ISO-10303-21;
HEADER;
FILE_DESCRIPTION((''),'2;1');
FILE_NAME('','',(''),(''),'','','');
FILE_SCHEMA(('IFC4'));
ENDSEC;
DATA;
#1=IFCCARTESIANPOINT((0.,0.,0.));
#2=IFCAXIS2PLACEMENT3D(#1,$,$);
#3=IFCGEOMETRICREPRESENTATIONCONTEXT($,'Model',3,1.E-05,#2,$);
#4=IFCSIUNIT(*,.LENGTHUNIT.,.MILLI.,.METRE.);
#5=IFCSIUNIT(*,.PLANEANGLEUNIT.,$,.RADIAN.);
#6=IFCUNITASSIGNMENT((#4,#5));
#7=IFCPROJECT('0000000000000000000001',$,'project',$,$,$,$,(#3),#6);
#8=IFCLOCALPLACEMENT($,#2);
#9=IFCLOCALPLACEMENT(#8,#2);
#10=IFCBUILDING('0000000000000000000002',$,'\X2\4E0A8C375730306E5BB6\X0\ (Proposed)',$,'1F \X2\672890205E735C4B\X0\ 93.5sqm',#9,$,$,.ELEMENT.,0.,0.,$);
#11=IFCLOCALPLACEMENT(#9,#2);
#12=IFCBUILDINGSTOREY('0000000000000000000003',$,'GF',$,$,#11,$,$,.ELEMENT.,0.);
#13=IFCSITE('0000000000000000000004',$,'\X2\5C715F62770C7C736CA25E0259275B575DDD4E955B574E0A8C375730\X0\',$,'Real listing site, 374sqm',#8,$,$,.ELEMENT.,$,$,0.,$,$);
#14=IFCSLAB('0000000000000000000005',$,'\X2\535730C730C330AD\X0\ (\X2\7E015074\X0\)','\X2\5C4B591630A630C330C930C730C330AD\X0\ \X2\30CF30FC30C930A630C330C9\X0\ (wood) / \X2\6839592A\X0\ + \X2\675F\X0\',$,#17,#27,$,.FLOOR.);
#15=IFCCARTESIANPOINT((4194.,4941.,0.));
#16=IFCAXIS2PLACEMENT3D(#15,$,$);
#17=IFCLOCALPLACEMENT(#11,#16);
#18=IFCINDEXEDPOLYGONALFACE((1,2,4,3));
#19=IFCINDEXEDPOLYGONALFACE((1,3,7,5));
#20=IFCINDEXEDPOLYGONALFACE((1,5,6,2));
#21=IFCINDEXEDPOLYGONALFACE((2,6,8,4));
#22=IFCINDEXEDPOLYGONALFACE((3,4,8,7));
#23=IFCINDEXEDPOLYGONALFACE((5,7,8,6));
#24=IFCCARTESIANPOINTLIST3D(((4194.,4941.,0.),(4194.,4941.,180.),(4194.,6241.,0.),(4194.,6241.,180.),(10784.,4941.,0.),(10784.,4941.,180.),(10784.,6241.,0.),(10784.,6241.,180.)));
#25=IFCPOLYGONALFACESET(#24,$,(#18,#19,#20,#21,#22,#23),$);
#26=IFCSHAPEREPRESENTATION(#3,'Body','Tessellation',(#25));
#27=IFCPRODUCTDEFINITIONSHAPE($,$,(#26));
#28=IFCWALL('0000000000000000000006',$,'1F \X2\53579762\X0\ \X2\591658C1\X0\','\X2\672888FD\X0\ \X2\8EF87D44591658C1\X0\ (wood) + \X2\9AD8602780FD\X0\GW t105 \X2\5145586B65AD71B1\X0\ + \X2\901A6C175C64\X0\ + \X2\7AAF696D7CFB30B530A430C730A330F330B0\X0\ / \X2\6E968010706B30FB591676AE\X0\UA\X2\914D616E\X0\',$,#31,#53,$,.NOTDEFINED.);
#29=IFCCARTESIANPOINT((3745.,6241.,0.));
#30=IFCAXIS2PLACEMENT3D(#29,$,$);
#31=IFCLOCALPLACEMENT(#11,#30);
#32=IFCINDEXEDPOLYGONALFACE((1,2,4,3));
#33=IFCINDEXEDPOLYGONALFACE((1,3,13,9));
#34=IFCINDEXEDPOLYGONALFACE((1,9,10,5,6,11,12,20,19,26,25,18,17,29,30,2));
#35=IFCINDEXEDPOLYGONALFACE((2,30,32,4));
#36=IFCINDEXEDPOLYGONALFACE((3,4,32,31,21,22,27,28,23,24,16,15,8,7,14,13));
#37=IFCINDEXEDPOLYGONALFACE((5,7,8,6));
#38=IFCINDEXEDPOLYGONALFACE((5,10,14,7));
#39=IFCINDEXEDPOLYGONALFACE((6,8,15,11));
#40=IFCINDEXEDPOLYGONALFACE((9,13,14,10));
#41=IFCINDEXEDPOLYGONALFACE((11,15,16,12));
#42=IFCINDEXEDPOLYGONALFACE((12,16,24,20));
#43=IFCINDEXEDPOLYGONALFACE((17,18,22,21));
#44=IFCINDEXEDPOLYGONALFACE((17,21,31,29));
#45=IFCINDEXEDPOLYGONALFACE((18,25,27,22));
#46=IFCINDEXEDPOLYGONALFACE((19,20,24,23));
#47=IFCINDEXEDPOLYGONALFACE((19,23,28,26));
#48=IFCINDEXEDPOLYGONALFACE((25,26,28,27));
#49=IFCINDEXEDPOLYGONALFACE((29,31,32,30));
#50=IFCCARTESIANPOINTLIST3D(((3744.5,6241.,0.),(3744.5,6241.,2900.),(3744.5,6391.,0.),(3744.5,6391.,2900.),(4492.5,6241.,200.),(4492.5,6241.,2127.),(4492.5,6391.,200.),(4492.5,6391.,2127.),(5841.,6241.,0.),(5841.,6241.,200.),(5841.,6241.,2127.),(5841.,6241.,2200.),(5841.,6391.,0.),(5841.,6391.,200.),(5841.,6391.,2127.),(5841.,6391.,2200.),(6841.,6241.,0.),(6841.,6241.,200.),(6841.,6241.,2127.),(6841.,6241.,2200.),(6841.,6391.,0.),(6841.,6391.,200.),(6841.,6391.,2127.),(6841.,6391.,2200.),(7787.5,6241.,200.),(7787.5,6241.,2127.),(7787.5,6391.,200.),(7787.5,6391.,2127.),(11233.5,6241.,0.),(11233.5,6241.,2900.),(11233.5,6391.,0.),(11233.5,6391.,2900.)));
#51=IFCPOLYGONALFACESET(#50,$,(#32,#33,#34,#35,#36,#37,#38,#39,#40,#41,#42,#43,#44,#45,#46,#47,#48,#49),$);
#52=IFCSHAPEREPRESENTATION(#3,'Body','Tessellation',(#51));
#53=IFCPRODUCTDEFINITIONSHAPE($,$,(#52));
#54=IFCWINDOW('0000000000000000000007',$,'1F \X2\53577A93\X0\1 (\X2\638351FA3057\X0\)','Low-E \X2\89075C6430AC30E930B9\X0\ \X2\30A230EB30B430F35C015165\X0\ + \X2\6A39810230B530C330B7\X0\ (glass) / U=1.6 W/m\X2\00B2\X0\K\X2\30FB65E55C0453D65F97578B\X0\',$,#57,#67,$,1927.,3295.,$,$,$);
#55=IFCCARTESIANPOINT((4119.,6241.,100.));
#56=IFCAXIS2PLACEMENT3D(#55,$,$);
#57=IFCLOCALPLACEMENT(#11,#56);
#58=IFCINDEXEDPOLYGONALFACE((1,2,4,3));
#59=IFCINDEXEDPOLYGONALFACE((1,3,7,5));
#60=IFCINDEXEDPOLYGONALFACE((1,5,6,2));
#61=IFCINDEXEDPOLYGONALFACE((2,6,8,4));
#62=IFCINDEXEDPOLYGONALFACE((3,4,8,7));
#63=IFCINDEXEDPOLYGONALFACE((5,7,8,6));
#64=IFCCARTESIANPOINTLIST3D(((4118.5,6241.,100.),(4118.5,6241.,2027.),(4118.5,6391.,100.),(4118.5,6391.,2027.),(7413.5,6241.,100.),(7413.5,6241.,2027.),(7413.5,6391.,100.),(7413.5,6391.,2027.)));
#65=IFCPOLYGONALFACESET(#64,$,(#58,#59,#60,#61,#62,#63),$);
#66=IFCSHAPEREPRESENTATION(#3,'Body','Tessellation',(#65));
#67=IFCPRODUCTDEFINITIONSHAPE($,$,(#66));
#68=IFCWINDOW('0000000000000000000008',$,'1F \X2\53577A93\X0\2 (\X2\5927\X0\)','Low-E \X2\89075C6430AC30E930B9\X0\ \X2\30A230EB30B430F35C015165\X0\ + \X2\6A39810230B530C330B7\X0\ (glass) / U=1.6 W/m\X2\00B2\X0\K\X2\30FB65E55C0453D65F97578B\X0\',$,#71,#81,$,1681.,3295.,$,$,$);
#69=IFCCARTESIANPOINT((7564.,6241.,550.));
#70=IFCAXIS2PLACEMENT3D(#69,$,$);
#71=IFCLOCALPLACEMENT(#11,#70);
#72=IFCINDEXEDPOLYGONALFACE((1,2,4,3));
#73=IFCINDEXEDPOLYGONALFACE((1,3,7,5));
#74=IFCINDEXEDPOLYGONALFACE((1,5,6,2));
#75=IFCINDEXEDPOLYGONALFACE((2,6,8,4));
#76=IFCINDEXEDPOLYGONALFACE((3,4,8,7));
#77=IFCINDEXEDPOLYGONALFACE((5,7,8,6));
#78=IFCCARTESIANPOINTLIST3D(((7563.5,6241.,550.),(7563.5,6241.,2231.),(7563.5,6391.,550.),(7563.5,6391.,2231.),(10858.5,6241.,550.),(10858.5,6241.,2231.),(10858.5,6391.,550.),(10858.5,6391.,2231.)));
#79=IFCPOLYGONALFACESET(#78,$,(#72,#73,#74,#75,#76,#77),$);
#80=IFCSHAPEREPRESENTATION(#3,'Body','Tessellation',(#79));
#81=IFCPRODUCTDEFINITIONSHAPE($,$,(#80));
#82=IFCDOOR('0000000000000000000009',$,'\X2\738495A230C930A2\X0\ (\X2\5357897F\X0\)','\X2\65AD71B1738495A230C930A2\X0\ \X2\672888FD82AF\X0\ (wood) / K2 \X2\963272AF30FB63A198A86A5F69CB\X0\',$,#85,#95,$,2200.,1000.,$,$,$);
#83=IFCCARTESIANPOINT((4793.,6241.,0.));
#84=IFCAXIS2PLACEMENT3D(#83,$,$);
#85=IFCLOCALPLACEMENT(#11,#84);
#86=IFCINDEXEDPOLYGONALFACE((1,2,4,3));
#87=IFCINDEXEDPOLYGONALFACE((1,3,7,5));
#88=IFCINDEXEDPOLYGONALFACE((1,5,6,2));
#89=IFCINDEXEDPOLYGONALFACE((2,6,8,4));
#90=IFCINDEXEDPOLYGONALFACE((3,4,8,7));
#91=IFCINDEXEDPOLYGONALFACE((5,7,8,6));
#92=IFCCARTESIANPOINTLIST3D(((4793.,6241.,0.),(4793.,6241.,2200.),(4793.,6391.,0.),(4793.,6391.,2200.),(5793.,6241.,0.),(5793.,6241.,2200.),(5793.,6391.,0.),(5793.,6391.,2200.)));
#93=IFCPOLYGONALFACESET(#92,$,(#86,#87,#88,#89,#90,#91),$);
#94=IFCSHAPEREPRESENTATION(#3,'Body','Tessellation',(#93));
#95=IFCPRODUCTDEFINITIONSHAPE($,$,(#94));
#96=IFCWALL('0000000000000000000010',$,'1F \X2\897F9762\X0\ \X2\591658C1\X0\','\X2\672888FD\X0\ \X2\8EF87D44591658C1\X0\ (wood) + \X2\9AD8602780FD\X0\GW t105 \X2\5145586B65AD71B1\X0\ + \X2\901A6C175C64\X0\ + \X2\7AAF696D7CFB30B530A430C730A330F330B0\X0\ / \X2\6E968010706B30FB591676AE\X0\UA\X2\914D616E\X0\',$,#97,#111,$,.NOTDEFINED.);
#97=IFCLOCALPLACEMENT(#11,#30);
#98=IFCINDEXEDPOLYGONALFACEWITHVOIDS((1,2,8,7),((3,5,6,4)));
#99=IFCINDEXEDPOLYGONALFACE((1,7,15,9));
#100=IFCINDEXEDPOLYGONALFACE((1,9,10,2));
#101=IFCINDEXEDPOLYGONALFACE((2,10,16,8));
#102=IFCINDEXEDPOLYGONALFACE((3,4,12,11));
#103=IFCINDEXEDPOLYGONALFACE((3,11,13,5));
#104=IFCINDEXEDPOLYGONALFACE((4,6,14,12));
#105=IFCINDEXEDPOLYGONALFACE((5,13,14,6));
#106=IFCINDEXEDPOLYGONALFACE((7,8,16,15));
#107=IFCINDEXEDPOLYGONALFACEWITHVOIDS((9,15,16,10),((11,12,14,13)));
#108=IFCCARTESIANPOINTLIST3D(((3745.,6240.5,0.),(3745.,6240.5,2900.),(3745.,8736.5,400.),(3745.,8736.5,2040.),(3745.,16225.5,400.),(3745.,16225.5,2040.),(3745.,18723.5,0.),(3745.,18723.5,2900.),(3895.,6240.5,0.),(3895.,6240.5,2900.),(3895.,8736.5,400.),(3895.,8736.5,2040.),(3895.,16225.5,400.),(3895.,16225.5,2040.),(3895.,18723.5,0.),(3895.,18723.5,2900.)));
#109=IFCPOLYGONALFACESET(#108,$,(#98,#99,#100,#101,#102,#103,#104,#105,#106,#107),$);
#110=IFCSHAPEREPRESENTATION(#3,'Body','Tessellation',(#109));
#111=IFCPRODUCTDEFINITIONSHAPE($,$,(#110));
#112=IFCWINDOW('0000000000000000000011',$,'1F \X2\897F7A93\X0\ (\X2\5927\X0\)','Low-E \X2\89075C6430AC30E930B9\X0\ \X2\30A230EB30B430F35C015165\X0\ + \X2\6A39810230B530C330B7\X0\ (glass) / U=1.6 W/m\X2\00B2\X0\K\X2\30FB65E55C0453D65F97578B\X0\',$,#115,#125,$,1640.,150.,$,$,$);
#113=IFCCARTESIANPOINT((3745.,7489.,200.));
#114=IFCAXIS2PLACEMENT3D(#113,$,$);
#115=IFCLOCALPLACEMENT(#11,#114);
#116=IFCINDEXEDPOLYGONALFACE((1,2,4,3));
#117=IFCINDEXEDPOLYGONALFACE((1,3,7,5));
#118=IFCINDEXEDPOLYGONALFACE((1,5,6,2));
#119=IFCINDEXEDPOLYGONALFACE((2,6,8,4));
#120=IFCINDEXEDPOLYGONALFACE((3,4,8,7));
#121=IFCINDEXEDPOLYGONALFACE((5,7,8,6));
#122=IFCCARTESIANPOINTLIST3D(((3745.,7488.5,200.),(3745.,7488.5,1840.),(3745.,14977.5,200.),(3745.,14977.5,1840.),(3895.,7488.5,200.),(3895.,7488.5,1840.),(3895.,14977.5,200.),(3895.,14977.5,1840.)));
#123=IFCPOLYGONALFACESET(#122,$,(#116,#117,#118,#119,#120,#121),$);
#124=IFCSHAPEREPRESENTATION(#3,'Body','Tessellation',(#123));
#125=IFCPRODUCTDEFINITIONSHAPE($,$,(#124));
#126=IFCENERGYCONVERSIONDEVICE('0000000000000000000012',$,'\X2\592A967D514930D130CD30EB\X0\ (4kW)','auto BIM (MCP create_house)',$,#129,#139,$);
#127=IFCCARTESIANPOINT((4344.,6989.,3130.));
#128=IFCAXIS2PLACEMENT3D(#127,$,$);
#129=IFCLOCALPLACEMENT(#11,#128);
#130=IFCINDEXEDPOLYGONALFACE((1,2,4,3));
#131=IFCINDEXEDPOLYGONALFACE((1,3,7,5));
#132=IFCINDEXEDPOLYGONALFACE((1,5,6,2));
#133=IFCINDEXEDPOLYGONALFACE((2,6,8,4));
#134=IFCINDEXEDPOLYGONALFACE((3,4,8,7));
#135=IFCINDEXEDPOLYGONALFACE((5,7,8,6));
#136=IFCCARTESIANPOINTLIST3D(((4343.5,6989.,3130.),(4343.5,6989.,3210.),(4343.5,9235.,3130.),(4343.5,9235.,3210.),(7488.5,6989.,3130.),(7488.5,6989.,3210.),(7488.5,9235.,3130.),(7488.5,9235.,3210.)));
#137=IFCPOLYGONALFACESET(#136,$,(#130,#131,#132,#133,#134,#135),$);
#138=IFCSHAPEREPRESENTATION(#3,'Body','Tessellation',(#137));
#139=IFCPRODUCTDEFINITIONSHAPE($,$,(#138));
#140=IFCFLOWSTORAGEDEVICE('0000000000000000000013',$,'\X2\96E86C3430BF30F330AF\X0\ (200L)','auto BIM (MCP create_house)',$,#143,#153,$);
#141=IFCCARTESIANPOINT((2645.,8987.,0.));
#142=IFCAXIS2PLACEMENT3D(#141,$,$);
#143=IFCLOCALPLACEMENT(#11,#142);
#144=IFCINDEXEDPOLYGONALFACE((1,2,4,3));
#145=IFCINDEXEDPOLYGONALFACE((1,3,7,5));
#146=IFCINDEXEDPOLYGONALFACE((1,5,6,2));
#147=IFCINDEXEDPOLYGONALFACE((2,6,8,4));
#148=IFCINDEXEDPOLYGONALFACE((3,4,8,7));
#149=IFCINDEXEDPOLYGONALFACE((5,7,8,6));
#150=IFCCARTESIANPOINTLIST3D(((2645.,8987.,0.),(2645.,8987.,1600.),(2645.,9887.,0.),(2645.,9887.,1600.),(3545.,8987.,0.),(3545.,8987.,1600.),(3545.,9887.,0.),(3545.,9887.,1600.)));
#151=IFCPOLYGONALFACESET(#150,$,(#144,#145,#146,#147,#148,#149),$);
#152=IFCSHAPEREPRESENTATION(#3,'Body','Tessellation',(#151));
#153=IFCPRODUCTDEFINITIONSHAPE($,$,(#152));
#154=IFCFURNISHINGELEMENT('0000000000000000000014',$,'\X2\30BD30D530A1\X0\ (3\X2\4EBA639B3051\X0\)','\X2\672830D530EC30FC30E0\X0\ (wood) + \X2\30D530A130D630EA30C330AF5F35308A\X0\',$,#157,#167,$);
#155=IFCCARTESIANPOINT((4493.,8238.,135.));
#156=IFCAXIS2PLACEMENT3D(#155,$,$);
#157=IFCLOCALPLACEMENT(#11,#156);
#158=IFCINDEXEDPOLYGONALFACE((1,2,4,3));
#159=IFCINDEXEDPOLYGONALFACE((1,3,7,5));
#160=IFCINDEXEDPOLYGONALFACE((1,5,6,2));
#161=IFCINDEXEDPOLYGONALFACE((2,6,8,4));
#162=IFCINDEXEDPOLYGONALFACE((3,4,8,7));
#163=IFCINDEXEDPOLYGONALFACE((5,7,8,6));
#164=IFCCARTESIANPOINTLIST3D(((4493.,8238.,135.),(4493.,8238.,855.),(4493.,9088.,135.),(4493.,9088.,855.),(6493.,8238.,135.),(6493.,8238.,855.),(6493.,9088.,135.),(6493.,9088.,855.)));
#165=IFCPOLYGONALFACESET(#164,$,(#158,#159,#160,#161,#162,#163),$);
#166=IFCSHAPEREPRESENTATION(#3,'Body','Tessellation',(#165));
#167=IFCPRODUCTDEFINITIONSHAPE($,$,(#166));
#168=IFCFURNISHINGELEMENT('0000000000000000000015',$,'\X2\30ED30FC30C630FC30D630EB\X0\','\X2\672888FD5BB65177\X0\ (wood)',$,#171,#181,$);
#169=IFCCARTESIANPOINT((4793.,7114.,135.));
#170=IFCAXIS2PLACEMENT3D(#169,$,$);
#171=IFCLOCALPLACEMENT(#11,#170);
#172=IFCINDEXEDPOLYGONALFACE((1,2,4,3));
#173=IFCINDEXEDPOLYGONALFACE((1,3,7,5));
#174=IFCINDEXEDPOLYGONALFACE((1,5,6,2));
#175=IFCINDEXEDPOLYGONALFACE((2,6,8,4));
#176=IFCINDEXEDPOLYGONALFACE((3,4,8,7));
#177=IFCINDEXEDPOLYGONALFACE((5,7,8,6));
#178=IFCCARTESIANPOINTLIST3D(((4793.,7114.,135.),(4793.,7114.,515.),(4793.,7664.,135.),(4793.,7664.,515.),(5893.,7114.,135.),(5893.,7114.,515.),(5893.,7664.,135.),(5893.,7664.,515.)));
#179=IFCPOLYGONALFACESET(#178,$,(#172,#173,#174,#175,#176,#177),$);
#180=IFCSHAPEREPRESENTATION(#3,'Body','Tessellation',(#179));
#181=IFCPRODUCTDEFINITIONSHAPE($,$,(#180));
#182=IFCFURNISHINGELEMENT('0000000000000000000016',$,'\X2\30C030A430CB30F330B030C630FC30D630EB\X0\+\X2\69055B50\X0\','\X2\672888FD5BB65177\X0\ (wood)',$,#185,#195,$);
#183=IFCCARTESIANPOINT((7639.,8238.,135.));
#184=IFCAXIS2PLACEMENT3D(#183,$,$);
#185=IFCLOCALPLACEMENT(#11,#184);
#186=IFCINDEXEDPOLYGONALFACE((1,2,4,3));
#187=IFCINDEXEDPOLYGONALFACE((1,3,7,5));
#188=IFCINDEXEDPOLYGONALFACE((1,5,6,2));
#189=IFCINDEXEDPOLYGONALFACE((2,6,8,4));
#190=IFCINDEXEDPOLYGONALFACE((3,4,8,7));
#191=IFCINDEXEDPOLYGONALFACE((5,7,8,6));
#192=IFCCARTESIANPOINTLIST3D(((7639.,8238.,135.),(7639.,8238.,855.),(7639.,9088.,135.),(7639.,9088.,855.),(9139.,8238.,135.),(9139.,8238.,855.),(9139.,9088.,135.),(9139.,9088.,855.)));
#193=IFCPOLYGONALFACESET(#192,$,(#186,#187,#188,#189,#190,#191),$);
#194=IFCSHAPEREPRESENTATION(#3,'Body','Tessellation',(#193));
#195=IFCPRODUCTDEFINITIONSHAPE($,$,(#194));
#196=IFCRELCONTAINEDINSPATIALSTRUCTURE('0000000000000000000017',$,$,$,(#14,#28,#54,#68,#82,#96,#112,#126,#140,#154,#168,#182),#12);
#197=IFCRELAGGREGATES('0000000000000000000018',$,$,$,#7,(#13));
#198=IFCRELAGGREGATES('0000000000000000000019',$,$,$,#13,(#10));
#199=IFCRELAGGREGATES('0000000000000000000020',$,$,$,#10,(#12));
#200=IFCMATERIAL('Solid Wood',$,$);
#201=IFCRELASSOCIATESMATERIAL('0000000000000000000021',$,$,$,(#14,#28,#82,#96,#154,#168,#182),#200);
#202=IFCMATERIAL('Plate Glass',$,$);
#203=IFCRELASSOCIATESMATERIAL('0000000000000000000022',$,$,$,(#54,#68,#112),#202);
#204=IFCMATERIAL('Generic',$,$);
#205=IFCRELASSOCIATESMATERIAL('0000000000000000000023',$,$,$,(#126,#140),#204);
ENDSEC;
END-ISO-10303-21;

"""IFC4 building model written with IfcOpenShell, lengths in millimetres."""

from ifc_helpers import new_model, si_unit, frame, frame_2d, origin, place, context, project, spatial, rectangle, extrude, material, element, fill, save


model = new_model("IFC4")

# Units and contexts
model_context = context("Model", 3, precision=1e-05, world=origin())
ifc_project = project(units=[si_unit("LENGTHUNIT", "METRE", prefix="MILLI"), si_unit("PLANEANGLEUNIT", "RADIAN")], contexts=[model_context])

# Site, building, storey
site_placement = place(None, origin())
site = spatial("IfcSite", under=ifc_project, at=site_placement, Name="山形県米沢市大字川井字上谷地", ObjectType="Real listing site, 374sqm", CompositionType="ELEMENT", RefElevation=0.0)
building_placement = place(site_placement, origin())
building = spatial("IfcBuilding", under=site, at=building_placement, Name="上谷地の家 (Proposed)", ObjectType="1F 木造平屋 93.5sqm", CompositionType="ELEMENT", ElevationOfRefHeight=0.0, ElevationOfTerrain=0.0)
storey_placement = place(building_placement, origin())
storey = spatial("IfcBuildingStorey", under=building, at=storey_placement, Name="GF", CompositionType="ELEMENT", Elevation=0.0)

# Slab
ifc_material_1 = material(Name="Solid Wood")
slab_1_placement = place(storey_placement, frame((4194.0, 4941.0, 0.0)))
element("IfcSlab", 1, at=slab_1_placement, inside=storey, material=ifc_material_1, Name="南デッキ (縁側)", Description="屋外ウッドデッキ ハードウッド (wood) / 根太 + 束", PredefinedType="FLOOR", context=model_context, shape_type="SweptSolid", body=[
    extrude(rectangle(XDim=6590.0, YDim=1300.0, at=frame_2d((3295.0, 650.0))), frame((4194.0, 4941.0, 0.0)), (0.0, 0.0, 1.0), 180.0),
])

# Wall, openings, windows, door
wall_1_placement = place(storey_placement, frame((3745.0, 6241.0, 0.0)))
wall_1 = element("IfcWall", 2, at=wall_1_placement, inside=storey, material=ifc_material_1, Name="1F 南面 外壁", Description="木製 軸組外壁 (wood) + 高性能GW t105 充填断熱 + 通気層 + 窯業系サイディング / 準耐火・外皮UA配慮", PredefinedType="NOTDEFINED", context=model_context, shape_type="SweptSolid", body=[
    extrude(rectangle(XDim=7489.0, YDim=150.0, at=frame_2d((3744.0, 75.0))), frame((3745.0, 6241.0, 0.0)), (0.0, 0.0, 1.0), 2900.0),
])
opening_1_placement = place(storey_placement, frame((4119.0, 6241.0, 100.0)))
opening_1 = element("IfcOpeningElement", 3, at=opening_1_placement, cuts=wall_1, PredefinedType="NOTDEFINED", context=model_context, shape_type="SweptSolid", body=[
    extrude(rectangle(XDim=3295.0, YDim=150.0, at=frame_2d((1647.0, 75.0))), frame((4119.0, 6241.0, 100.0)), (0.0, 0.0, 1.0), 1927.0),
])
opening_2_placement = place(storey_placement, frame((7564.0, 6241.0, 550.0)))
opening_2 = element("IfcOpeningElement", 4, at=opening_2_placement, cuts=wall_1, PredefinedType="NOTDEFINED", context=model_context, shape_type="SweptSolid", body=[
    extrude(rectangle(XDim=3295.0, YDim=150.0, at=frame_2d((1647.0, 75.0))), frame((7564.0, 6241.0, 550.0)), (0.0, 0.0, 1.0), 1681.0),
])
opening_3_placement = place(storey_placement, frame((4793.0, 6241.0, 0.0)))
opening_3 = element("IfcOpeningElement", 5, at=opening_3_placement, cuts=wall_1, PredefinedType="NOTDEFINED", context=model_context, shape_type="SweptSolid", body=[
    extrude(rectangle(XDim=1000.0, YDim=150.0, at=frame_2d((500.0, 75.0))), frame((4793.0, 6241.0, 0.0)), (0.0, 0.0, 1.0), 2200.0),
])
ifc_material_2 = material(Name="Plate Glass")
window_1_placement = place(storey_placement, frame((4119.0, 6241.0, 100.0)))
window_1 = element("IfcWindow", 6, at=window_1_placement, inside=storey, material=ifc_material_2, Name="1F 南窓1 (掃出し)", Description="Low-E 複層ガラス アルゴン封入 + 樹脂サッシ (glass) / U=1.6 W/m²K・日射取得型", OverallHeight=1927.0, OverallWidth=3295.0, context=model_context, shape_type="SweptSolid", body=[
    extrude(rectangle(XDim=3295.0, YDim=150.0, at=frame_2d((1647.0, 75.0))), frame((4119.0, 6241.0, 100.0)), (0.0, 0.0, 1.0), 1927.0),
])
fill(opening_1, window_1)
window_2_placement = place(storey_placement, frame((7564.0, 6241.0, 550.0)))
window_2 = element("IfcWindow", 7, at=window_2_placement, inside=storey, material=ifc_material_2, Name="1F 南窓2 (大)", Description="Low-E 複層ガラス アルゴン封入 + 樹脂サッシ (glass) / U=1.6 W/m²K・日射取得型", OverallHeight=1681.0, OverallWidth=3295.0, context=model_context, shape_type="SweptSolid", body=[
    extrude(rectangle(XDim=3295.0, YDim=150.0, at=frame_2d((1647.0, 75.0))), frame((7564.0, 6241.0, 550.0)), (0.0, 0.0, 1.0), 1681.0),
])
fill(opening_2, window_2)
door_placement = place(storey_placement, frame((4793.0, 6241.0, 0.0)))
door = element("IfcDoor", 8, at=door_placement, inside=storey, material=ifc_material_1, Name="玄関ドア (南西)", Description="断熱玄関ドア 木製芯 (wood) / K2 防犯・採風機構", OverallHeight=2200.0, OverallWidth=1000.0, context=model_context, shape_type="SweptSolid", body=[
    extrude(rectangle(XDim=1000.0, YDim=150.0, at=frame_2d((500.0, 75.0))), frame((4793.0, 6241.0, 0.0)), (0.0, 0.0, 1.0), 2200.0),
])
fill(opening_3, door)

# Wall, opening, window
wall_2_placement = place(storey_placement, frame((3745.0, 6241.0, 0.0)))
wall_2 = element("IfcWall", 9, at=wall_2_placement, inside=storey, material=ifc_material_1, Name="1F 西面 外壁", Description="木製 軸組外壁 (wood) + 高性能GW t105 充填断熱 + 通気層 + 窯業系サイディング / 準耐火・外皮UA配慮", PredefinedType="NOTDEFINED", context=model_context, shape_type="SweptSolid", body=[
    extrude(rectangle(XDim=150.0, YDim=12483.0, at=frame_2d((75.0, 6241.0))), frame((3745.0, 6241.0, 0.0)), (0.0, 0.0, 1.0), 2900.0),
])
opening_4_placement = place(storey_placement, frame((3745.0, 7489.0, 200.0)))
opening_4 = element("IfcOpeningElement", 10, at=opening_4_placement, cuts=wall_2, PredefinedType="NOTDEFINED", context=model_context, shape_type="SweptSolid", body=[
    extrude(rectangle(XDim=150.0, YDim=7489.0, at=frame_2d((75.0, 3744.0))), frame((3745.0, 7489.0, 200.0)), (0.0, 0.0, 1.0), 1640.0),
])
window_3_placement = place(storey_placement, frame((3745.0, 7489.0, 200.0)))
window_3 = element("IfcWindow", 11, at=window_3_placement, inside=storey, material=ifc_material_2, Name="1F 西窓 (大)", Description="Low-E 複層ガラス アルゴン封入 + 樹脂サッシ (glass) / U=1.6 W/m²K・日射取得型", OverallHeight=1640.0, OverallWidth=150.0, context=model_context, shape_type="SweptSolid", body=[
    extrude(rectangle(XDim=150.0, YDim=7489.0, at=frame_2d((75.0, 3744.0))), frame((3745.0, 7489.0, 200.0)), (0.0, 0.0, 1.0), 1640.0),
])
fill(opening_4, window_3)

# Shared definitions
ifc_material_3 = material(Name="Generic")

# Energy conversion device
energy_conversion_device_placement = place(storey_placement, frame((4344.0, 6989.0, 3130.0)))
element("IfcEnergyConversionDevice", 12, at=energy_conversion_device_placement, inside=storey, material=ifc_material_3, Name="太陽光パネル (4kW)", Description="auto BIM (MCP create_house)", context=model_context, shape_type="SweptSolid", body=[
    extrude(rectangle(XDim=3145.0, YDim=2246.0, at=frame_2d((1572.0, 1123.0))), frame((4344.0, 6989.0, 3130.0)), (0.0, 0.0, 1.0), 80.0),
])

# Flow storage device
flow_storage_device_placement = place(storey_placement, frame((2645.0, 8987.0, 0.0)))
element("IfcFlowStorageDevice", 13, at=flow_storage_device_placement, inside=storey, material=ifc_material_3, Name="雨水タンク (200L)", Description="auto BIM (MCP create_house)", context=model_context, shape_type="SweptSolid", body=[
    extrude(rectangle(XDim=900.0, YDim=900.0, at=frame_2d((450.0, 450.0))), frame((2645.0, 8987.0, 0.0)), (0.0, 0.0, 1.0), 1600.0),
])

# Furnishing elements
furnishing_1_placement = place(storey_placement, frame((4493.0, 8238.0, 135.0)))
element("IfcFurnishingElement", 14, at=furnishing_1_placement, inside=storey, material=ifc_material_1, Name="ソファ (3人掛け)", Description="木フレーム (wood) + ファブリック張り", context=model_context, shape_type="SweptSolid", body=[
    extrude(rectangle(XDim=2000.0, YDim=850.0, at=frame_2d((1000.0, 425.0))), frame((4493.0, 8238.0, 135.0)), (0.0, 0.0, 1.0), 720.0),
])
furnishing_2_placement = place(storey_placement, frame((4793.0, 7114.0, 135.0)))
element("IfcFurnishingElement", 15, at=furnishing_2_placement, inside=storey, material=ifc_material_1, Name="ローテーブル", Description="木製家具 (wood)", context=model_context, shape_type="SweptSolid", body=[
    extrude(rectangle(XDim=1100.0, YDim=550.0, at=frame_2d((550.0, 275.0))), frame((4793.0, 7114.0, 135.0)), (0.0, 0.0, 1.0), 380.0),
])
furnishing_3_placement = place(storey_placement, frame((7639.0, 8238.0, 135.0)))
element("IfcFurnishingElement", 16, at=furnishing_3_placement, inside=storey, material=ifc_material_1, Name="ダイニングテーブル+椅子", Description="木製家具 (wood)", context=model_context, shape_type="SweptSolid", body=[
    extrude(rectangle(XDim=1500.0, YDim=850.0, at=frame_2d((750.0, 425.0))), frame((7639.0, 8238.0, 135.0)), (0.0, 0.0, 1.0), 720.0),
])

save(model, "model.ifc")
